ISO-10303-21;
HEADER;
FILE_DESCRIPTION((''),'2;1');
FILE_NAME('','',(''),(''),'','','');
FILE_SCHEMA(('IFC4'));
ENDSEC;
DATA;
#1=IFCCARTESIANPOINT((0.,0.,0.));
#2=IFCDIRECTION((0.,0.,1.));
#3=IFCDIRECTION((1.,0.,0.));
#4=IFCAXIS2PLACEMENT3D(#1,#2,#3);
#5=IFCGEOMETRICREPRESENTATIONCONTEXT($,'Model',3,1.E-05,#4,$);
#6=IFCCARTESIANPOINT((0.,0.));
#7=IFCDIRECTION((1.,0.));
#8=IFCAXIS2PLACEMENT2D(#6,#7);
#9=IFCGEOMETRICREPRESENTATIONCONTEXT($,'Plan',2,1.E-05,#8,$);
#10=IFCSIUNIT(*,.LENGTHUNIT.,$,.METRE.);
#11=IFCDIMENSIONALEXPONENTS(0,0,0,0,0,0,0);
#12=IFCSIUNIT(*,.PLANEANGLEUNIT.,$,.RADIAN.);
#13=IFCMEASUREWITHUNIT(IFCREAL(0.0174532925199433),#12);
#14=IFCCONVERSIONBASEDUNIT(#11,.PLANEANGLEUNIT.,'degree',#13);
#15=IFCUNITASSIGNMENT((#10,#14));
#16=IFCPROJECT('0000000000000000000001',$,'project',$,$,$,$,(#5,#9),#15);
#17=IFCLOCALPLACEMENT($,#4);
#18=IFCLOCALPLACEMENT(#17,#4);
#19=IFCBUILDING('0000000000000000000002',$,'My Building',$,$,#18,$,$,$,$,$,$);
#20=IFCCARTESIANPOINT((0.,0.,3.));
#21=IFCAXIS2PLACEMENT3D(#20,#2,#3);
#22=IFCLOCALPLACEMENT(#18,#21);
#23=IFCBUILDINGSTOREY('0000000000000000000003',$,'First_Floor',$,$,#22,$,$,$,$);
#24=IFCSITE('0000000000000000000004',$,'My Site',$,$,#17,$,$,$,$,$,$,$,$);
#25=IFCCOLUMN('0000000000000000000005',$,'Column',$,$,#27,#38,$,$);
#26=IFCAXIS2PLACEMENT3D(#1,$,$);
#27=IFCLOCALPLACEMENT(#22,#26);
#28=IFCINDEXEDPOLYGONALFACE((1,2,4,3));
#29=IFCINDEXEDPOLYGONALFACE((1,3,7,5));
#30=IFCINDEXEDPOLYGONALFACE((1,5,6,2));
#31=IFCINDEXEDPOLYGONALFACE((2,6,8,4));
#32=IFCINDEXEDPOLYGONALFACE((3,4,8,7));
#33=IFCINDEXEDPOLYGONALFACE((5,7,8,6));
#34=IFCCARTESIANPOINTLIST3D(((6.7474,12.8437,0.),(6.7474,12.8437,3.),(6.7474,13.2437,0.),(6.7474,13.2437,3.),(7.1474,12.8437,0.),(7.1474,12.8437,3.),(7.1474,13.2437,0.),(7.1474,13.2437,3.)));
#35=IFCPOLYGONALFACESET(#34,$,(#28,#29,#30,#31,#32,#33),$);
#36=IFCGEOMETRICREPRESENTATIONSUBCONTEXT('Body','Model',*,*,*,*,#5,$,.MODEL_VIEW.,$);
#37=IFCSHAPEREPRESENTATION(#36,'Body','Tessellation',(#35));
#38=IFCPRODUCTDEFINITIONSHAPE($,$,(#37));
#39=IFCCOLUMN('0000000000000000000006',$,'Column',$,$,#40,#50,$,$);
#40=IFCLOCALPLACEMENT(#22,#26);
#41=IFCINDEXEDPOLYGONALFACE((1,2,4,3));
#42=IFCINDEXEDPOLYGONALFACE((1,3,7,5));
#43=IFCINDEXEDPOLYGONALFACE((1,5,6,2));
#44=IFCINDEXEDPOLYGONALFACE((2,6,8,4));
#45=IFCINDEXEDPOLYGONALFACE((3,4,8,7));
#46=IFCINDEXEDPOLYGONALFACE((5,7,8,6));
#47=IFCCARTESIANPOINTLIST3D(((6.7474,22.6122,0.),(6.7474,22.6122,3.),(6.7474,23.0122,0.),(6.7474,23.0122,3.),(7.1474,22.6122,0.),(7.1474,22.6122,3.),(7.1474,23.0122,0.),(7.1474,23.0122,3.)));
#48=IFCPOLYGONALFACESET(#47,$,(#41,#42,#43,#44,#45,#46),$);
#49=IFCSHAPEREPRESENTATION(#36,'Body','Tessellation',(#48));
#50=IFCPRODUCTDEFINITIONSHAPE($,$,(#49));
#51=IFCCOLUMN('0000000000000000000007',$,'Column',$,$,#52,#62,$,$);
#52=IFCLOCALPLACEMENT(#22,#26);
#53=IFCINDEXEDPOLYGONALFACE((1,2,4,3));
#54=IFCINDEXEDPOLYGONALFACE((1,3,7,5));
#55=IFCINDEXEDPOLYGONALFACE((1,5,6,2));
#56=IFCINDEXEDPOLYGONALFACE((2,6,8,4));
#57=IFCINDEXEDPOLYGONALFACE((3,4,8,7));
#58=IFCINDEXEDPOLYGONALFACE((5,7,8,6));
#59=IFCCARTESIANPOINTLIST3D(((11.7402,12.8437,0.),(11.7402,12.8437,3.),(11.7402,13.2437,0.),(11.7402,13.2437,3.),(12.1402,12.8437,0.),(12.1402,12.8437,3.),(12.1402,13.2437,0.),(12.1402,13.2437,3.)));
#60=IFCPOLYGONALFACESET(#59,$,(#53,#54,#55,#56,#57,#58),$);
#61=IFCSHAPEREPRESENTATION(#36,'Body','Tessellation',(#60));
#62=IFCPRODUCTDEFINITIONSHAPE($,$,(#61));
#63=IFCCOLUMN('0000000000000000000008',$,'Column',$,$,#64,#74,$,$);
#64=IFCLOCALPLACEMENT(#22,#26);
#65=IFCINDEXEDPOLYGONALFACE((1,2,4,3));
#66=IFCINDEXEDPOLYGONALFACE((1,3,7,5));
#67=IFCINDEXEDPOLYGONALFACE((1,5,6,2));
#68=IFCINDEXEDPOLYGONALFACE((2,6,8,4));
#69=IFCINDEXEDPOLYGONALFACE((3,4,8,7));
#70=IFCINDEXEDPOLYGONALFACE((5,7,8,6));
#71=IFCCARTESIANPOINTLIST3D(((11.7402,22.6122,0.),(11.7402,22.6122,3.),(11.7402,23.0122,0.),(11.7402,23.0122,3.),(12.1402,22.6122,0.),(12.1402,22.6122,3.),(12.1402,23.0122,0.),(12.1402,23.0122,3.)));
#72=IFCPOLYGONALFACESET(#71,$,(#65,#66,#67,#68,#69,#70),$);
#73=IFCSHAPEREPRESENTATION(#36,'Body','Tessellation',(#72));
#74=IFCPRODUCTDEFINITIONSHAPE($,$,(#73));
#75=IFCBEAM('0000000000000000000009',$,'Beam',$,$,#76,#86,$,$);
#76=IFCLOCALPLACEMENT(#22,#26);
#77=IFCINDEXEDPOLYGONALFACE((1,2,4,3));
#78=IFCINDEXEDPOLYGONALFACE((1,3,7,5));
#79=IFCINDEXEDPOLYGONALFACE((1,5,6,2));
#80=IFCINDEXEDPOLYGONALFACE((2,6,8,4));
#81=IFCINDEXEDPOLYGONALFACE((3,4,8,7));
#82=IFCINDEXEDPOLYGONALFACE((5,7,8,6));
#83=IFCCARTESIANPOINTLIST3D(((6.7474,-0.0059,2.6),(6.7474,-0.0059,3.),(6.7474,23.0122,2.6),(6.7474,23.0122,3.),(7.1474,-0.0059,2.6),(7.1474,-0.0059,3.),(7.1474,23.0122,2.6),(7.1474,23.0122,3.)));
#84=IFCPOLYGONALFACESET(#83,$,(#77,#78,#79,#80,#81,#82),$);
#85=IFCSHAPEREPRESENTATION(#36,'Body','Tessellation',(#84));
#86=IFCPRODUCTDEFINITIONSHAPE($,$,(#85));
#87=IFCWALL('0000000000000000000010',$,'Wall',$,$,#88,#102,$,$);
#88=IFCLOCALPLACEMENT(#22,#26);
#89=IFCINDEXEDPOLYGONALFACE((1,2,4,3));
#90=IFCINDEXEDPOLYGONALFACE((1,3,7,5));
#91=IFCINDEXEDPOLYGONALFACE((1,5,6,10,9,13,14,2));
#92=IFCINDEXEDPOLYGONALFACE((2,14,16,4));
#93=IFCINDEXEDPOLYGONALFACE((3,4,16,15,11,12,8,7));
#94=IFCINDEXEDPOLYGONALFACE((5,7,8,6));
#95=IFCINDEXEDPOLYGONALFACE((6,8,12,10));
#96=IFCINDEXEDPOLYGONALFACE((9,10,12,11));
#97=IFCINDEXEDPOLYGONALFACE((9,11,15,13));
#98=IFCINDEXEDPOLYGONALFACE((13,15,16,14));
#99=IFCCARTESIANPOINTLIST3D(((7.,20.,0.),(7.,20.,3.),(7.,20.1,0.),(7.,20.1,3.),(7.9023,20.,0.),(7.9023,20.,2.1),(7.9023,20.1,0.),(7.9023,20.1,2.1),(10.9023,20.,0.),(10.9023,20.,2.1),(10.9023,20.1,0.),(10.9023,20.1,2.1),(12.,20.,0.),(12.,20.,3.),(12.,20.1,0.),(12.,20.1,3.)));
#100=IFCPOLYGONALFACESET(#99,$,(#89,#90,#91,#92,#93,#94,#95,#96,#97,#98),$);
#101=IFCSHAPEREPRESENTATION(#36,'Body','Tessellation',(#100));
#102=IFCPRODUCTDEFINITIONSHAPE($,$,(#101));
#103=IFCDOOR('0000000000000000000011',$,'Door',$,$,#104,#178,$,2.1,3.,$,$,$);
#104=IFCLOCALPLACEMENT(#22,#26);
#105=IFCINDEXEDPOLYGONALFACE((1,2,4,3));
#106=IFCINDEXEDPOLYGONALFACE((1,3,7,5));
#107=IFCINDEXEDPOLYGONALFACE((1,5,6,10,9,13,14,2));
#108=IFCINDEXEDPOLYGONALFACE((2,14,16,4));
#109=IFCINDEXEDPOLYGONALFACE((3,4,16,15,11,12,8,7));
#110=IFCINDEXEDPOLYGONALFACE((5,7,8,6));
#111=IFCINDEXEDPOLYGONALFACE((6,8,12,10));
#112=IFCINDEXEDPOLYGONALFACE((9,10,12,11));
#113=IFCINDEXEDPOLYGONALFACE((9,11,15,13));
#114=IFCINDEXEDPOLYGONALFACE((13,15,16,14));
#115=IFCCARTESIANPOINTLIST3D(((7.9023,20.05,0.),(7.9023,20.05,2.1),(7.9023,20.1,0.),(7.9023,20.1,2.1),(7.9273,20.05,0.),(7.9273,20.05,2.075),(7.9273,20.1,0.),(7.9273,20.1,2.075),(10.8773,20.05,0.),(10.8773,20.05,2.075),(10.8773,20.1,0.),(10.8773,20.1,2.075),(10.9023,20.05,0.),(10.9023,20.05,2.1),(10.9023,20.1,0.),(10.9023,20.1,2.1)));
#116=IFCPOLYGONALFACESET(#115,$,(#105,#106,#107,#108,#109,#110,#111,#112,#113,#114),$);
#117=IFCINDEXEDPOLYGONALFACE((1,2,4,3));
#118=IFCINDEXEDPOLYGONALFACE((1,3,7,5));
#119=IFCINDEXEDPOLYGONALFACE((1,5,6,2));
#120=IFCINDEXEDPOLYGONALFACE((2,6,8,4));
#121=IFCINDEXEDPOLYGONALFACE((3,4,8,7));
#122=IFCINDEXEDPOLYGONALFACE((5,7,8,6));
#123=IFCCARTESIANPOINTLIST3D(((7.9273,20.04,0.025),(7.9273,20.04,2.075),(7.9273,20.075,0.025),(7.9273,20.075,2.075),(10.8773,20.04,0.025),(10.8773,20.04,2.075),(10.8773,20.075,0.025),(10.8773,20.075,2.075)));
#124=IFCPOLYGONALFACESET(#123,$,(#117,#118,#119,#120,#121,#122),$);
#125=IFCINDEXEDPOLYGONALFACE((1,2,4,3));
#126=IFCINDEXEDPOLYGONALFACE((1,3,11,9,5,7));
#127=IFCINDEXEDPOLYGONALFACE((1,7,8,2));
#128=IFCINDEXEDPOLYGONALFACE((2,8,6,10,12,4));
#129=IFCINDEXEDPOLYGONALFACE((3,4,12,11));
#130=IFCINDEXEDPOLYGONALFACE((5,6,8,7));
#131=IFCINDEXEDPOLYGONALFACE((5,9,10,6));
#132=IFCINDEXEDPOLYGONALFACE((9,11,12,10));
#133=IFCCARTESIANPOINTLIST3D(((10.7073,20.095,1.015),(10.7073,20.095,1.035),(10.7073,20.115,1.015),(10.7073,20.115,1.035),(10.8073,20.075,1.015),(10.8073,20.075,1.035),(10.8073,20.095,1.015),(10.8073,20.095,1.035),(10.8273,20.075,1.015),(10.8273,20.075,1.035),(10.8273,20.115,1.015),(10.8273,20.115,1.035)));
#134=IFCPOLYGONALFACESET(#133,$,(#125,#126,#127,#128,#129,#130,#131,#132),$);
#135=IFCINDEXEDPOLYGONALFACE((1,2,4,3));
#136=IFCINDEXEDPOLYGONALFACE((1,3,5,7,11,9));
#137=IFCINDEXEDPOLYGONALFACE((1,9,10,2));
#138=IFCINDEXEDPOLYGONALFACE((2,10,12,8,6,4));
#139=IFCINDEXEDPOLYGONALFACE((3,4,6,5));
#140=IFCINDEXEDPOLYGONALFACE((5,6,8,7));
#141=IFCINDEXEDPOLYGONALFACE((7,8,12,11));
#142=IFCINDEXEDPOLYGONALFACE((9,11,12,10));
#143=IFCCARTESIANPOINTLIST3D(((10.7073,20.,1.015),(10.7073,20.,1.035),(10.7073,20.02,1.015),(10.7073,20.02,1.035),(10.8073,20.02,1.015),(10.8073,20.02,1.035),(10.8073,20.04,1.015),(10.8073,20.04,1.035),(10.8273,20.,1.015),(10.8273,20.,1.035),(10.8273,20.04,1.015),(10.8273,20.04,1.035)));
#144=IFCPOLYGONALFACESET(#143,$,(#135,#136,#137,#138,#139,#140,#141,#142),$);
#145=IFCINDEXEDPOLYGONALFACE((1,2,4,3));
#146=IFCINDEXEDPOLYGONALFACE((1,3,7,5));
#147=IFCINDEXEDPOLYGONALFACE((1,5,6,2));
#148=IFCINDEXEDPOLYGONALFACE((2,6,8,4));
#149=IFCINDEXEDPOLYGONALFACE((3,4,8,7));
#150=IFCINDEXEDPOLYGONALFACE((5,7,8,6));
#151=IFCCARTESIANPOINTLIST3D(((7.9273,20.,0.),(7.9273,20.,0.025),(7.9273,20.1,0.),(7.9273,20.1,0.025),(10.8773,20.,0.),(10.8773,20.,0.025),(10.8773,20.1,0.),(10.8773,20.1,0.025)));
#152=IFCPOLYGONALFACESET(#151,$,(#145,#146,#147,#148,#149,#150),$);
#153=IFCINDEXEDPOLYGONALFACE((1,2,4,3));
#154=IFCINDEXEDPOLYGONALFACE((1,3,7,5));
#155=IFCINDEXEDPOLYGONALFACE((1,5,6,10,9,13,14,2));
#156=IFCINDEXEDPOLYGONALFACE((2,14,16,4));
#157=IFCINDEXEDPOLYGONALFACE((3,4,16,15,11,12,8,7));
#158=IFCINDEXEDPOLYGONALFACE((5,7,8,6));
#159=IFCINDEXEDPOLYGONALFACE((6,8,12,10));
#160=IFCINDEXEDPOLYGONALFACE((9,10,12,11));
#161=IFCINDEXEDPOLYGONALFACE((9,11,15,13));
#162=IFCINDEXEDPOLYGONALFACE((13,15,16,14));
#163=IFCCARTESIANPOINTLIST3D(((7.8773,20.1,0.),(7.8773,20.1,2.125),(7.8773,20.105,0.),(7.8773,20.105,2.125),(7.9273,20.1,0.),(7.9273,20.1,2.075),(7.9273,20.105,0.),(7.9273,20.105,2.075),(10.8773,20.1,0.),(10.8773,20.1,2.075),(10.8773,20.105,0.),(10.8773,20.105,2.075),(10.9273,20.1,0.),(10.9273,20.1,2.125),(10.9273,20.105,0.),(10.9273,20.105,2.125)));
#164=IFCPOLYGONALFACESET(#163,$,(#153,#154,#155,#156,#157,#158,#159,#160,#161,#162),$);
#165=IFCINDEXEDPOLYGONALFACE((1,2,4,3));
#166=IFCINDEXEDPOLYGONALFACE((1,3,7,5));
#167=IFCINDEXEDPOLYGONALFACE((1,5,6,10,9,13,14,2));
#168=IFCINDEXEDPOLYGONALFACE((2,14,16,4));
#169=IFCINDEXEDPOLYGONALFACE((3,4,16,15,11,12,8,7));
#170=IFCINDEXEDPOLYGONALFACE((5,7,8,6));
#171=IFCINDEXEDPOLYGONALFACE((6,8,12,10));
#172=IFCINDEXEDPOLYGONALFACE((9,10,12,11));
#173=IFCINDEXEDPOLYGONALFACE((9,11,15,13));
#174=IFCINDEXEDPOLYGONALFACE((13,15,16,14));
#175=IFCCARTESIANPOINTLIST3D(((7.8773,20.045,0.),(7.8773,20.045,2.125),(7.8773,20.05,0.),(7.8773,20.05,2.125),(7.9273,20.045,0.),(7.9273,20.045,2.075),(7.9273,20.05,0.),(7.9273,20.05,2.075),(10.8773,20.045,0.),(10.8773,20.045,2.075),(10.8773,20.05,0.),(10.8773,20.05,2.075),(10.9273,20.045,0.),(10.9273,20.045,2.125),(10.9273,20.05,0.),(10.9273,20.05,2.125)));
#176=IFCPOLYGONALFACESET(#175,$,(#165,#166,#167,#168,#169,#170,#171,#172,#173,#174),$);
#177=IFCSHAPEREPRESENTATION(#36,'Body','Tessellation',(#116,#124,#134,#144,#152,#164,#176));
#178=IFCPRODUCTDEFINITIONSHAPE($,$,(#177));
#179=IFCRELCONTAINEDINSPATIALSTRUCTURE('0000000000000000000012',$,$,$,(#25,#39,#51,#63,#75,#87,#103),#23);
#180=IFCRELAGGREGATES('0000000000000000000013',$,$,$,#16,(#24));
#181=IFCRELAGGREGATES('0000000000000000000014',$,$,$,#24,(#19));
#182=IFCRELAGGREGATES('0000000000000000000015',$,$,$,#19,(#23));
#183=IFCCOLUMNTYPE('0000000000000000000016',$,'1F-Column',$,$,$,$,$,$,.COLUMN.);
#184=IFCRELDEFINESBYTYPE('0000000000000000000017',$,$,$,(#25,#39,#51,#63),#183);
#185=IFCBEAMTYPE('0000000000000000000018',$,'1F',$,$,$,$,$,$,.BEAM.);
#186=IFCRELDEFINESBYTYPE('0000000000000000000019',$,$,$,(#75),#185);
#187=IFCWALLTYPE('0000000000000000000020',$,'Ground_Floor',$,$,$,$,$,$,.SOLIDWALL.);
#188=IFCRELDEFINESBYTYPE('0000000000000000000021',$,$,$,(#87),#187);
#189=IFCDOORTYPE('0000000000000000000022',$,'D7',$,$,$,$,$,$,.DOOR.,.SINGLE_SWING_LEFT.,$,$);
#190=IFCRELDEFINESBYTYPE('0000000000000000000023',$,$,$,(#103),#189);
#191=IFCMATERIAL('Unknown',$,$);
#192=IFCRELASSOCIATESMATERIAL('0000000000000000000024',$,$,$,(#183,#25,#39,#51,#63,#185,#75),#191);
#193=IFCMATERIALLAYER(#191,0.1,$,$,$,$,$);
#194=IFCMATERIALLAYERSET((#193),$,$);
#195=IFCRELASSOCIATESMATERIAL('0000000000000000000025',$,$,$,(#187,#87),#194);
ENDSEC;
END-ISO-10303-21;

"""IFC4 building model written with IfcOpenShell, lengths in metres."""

from ifc_helpers import new_model, entity, si_unit, converted_unit, frame, origin_with_axes, origin_2d_with_axis, place, context, subcontext, project, spatial, line, indexed_curve, rectangle, outline, extrude, shape, source, transform, mapped, material, layer, layer_set, layer_usage, material_profile, profile_set, profile_usage, type_object, type_shapes, element, fill, save


model = new_model("IFC4")

# Units and contexts
model_context = context("Model", 3, precision=1e-05, world=origin_with_axes())
plan_context = context("Plan", 2, precision=1e-05, world=origin_2d_with_axis())
body_context_1 = subcontext(model_context, "Body", "Model", "MODEL_VIEW")
body_context_2 = subcontext(plan_context, "Body", "Plan", "PLAN_VIEW")
ifc_project = project(units=[si_unit("LENGTHUNIT", "METRE"), converted_unit("PLANEANGLEUNIT", "degree", entity("IfcReal", 0.0174532925199433), si_unit("PLANEANGLEUNIT", "RADIAN"), dimensions=[0, 0, 0, 0, 0, 0, 0])], contexts=[model_context, plan_context])

# Site, building, storey
site_placement = place(None, origin_with_axes())
site = spatial("IfcSite", under=ifc_project, at=site_placement, Name="My Site")
building_placement = place(site_placement, origin_with_axes())
building = spatial("IfcBuilding", under=site, at=building_placement, Name="My Building")
storey_placement = place(building_placement, frame((0.0, 0.0, 3.0), z_axis=(0.0, 0.0, 1.0), x_axis=(1.0, 0.0, 0.0)))
storey = spatial("IfcBuildingStorey", under=building, at=storey_placement, Name="First_Floor")

# Columns
ifc_material = material(Name="Unknown")
ifc_material_profile_1 = material_profile(ifc_material, rectangle(XDim=0.4, YDim=0.4))
ifc_profile_set_1 = profile_set([ifc_material_profile_1])
ifc_profile_usage_1 = profile_usage(ifc_profile_set_1, cardinal=5)
column_type = type_object("IfcColumnType", Name="1F-Column", PredefinedType="COLUMN", material=ifc_profile_set_1)
column_1_placement = place(storey_placement, frame((6.9474, 13.0437, 0.0), z_axis=(0.0, 0.0, 1.0), x_axis=(1.0, 0.0, 0.0)))
element("IfcColumn", 1, at=column_1_placement, inside=storey, type_object=column_type, material=ifc_profile_usage_1, Name="Column", context=body_context_1, shape_type="SweptSolid", body=[
    extrude(rectangle(XDim=0.4, YDim=0.4), origin_with_axes(), (0.0, 0.0, 1.0), 3.0),
])
ifc_profile_usage_2 = profile_usage(ifc_profile_set_1, cardinal=5)
column_2_placement = place(storey_placement, frame((6.9474, 22.8122, 0.0), z_axis=(0.0, 0.0, 1.0), x_axis=(1.0, 0.0, 0.0)))
element("IfcColumn", 2, at=column_2_placement, inside=storey, type_object=column_type, material=ifc_profile_usage_2, Name="Column", context=body_context_1, shape_type="SweptSolid", body=[
    extrude(rectangle(XDim=0.4, YDim=0.4), origin_with_axes(), (0.0, 0.0, 1.0), 3.0),
])
ifc_profile_usage_3 = profile_usage(ifc_profile_set_1, cardinal=5)
column_3_placement = place(storey_placement, frame((11.9402, 13.0437, 0.0), z_axis=(0.0, 0.0, 1.0), x_axis=(1.0, 0.0, 0.0)))
element("IfcColumn", 3, at=column_3_placement, inside=storey, type_object=column_type, material=ifc_profile_usage_3, Name="Column", context=body_context_1, shape_type="SweptSolid", body=[
    extrude(rectangle(XDim=0.4, YDim=0.4), origin_with_axes(), (0.0, 0.0, 1.0), 3.0),
])
ifc_profile_usage_4 = profile_usage(ifc_profile_set_1, cardinal=5)
column_4_placement = place(storey_placement, frame((11.9402, 22.8122, 0.0), z_axis=(0.0, 0.0, 1.0), x_axis=(1.0, 0.0, 0.0)))
element("IfcColumn", 4, at=column_4_placement, inside=storey, type_object=column_type, material=ifc_profile_usage_4, Name="Column", context=body_context_1, shape_type="SweptSolid", body=[
    extrude(rectangle(XDim=0.4, YDim=0.4), origin_with_axes(), (0.0, 0.0, 1.0), 3.0),
])

# Beam
ifc_material_profile_2 = material_profile(ifc_material, rectangle(XDim=0.4, YDim=0.4))
ifc_profile_set_2 = profile_set([ifc_material_profile_2])
ifc_profile_usage_5 = profile_usage(ifc_profile_set_2, cardinal=8)
beam_type = type_object("IfcBeamType", Name="1F", PredefinedType="BEAM", material=ifc_profile_set_2)
beam_placement = place(storey_placement, frame((6.9474, 23.0122, 3.0), z_axis=(0.0, -1.0, 0.0), x_axis=(1.0, 0.0, 0.0)))
element("IfcBeam", 5, at=beam_placement, inside=storey, type_object=beam_type, material=ifc_profile_usage_5, Name="Beam", context=body_context_1, shape_type="SweptSolid", body=[
    extrude(rectangle(XDim=0.4, YDim=0.4), frame((0.0, -0.2, 0.0), z_axis=(0.0, 0.0, 1.0), x_axis=(1.0, 0.0, 0.0)), (0.0, 0.0, 1.0), 23.0181),
])

# Wall, opening, door
ifc_layer = layer(ifc_material, 0.1)
ifc_layer_set = layer_set([ifc_layer])
ifc_layer_usage_1 = layer_usage(ifc_layer_set, "AXIS2", "POSITIVE", 0.0)
wall_type = type_object("IfcWallType", Name="Ground_Floor", PredefinedType="SOLIDWALL", material=ifc_layer_set)
wall_1_placement = place(storey_placement, frame((7.0, 20.0, 0.0), z_axis=(0.0, 0.0, 1.0), x_axis=(1.0, 0.0, 0.0)))
wall_1 = element("IfcWall", 6, at=wall_1_placement, inside=storey, type_object=wall_type, material=ifc_layer_usage_1, Name="Wall", context=body_context_1, shape_type="SweptSolid", body=[
    extrude(outline(indexed_curve([(0.0, 0.0), (0.0, 0.1), (5.0, 0.1), (5.0, 0.0)], segments=[line(1, 2, 3, 4, 1)])), origin_with_axes(), (0.0, 0.0, 1.0), 3.0),
])
shared_shape_1 = source(origin_with_axes(), body_context_1, "Body", "SweptSolid", [
    extrude(outline(indexed_curve([(0.0, 0.0), (3.0, 0.0), (3.0, 2.1), (0.0, 2.1)], segments=[line(1, 2, 3, 4, 1)])), frame((0.0, -0.6, 0.0), z_axis=(0.0, -1.0, 0.0), x_axis=(1.0, 0.0, 0.0)), (0.0, 0.0, -1.0), 1.2),
])
opening_1_placement = place(wall_1_placement, frame((3.9023, 0.1, 0.0), z_axis=(0.0, 0.0, 1.0), x_axis=(-1.0, 0.0, 0.0)))
opening_1 = element("IfcOpeningElement", 7, at=opening_1_placement, cuts=wall_1, PredefinedType="OPENING", context=body_context_1, shape_type="MappedRepresentation", body=[
    mapped(shared_shape_1, transform((0.0, 0.0, 0.0), x_axis=(1.0, 0.0, 0.0), y_axis=(0.0, 1.0, 0.0), z_axis=(0.0, 0.0, 1.0), scale=1.0)),
])
door_type_1 = type_object("IfcDoorType", Name="D7", OperationType="SINGLE_SWING_LEFT", PredefinedType="DOOR")
shared_shape_2 = source(origin_with_axes(), body_context_1, "Body", "SweptSolid", [
    extrude(outline(indexed_curve([(0.0, 0.0), (0.0, 2.1), (3.0, 2.1), (3.0, 0.0), (2.975, 0.0), (2.975, 2.075), (0.025, 2.075), (0.025, 0.0)], segments=[line(1, 2, 3, 4, 5, 6, 7, 8, 1)])), frame((0.0, 0.0, 0.0), z_axis=(0.0, -1.0, 0.0), x_axis=(1.0, 0.0, 0.0)), (0.0, 0.0, -1.0), 0.05),
    extrude(outline(indexed_curve([(0.0, 0.0), (2.95, 0.0), (2.95, 0.035), (0.0, 0.035)], segments=[line(1, 2, 3, 4, 1)])), frame((0.025, 0.025, 0.025), z_axis=(0.0, 0.0, 1.0), x_axis=(1.0, 0.0, 0.0)), (0.0, 0.0, 1.0), 2.05),
    extrude(outline(indexed_curve([(0.0, 0.0), (0.0, -0.04), (0.12, -0.04), (0.12, -0.02), (0.02, -0.02), (0.02, 0.0)], segments=[line(1, 2, 3, 4, 5, 6, 1)])), frame((0.075, 0.025, 1.015), z_axis=(0.0, 0.0, 1.0), x_axis=(1.0, 0.0, 0.0)), (0.0, 0.0, 1.0), 0.02),
    extrude(outline(indexed_curve([(0.0, 0.0), (0.0, 0.04), (0.12, 0.04), (0.12, 0.02), (0.02, 0.02), (0.02, 0.0)], segments=[line(1, 2, 3, 4, 5, 6, 1)])), frame((0.075, 0.06, 1.015), z_axis=(0.0, 0.0, 1.0), x_axis=(1.0, 0.0, 0.0)), (0.0, 0.0, 1.0), 0.02),
    extrude(outline(indexed_curve([(0.0, 0.0), (2.95, 0.0), (2.95, 0.1), (0.0, 0.1)], segments=[line(1, 2, 3, 4, 1)])), frame((0.025, 0.0, 0.0), z_axis=(0.0, 0.0, 1.0), x_axis=(1.0, 0.0, 0.0)), (0.0, 0.0, 1.0), 0.025),
    extrude(outline(indexed_curve([(0.0, 0.0), (0.0, 2.125), (3.05, 2.125), (3.05, 0.0), (3.0, 0.0), (3.0, 2.075), (0.05, 2.075), (0.05, 0.0)], segments=[line(1, 2, 3, 4, 5, 6, 7, 8, 1)])), frame((-0.025, -0.005, 0.0), z_axis=(0.0, -1.0, 0.0), x_axis=(1.0, 0.0, 0.0)), (0.0, 0.0, -1.0), 0.005),
    extrude(outline(indexed_curve([(0.0, 0.0), (0.0, 2.125), (3.05, 2.125), (3.05, 0.0), (3.0, 0.0), (3.0, 2.075), (0.05, 2.075), (0.05, 0.0)], segments=[line(1, 2, 3, 4, 5, 6, 7, 8, 1)])), frame((-0.025, 0.05, 0.0), z_axis=(0.0, -1.0, 0.0), x_axis=(1.0, 0.0, 0.0)), (0.0, 0.0, -1.0), 0.005),
])
shared_shape_3 = source(origin_with_axes(), body_context_2, "Body", "Curve2D", [
    entity("IfcIndexedPolyCurve", entity("IfcCartesianPointList2D", [[0.0, 0.0], [0.025, 0.0], [0.025, 0.05], [0.0, 0.05]]), [entity("IfcLineIndex", [1, 2, 3, 4, 1])]),
    entity("IfcIndexedPolyCurve", entity("IfcCartesianPointList2D", [[3.0, 0.0], [2.975, 0.0], [2.975, 0.05], [3.0, 0.05]]), [entity("IfcLineIndex", [1, 2, 3, 4, 1])]),
    entity("IfcIndexedPolyCurve", entity("IfcCartesianPointList2D", [[2.975, 0.05], [2.975, -2.9], [2.94, -2.9]])),
    entity("IfcTrimmedCurve", entity("IfcEllipse", entity("IfcAxis2Placement2D", entity("IfcCartesianPoint", [2.94, 0.05]), entity("IfcDirection", [1.0, 0.0])), 2.915, 2.95), [entity("IfcCartesianPoint", [2.94, 3.0])], [entity("IfcCartesianPoint", [2.94, -2.9])], True, "CARTESIAN"),
    entity("IfcIndexedPolyCurve", entity("IfcCartesianPointList2D", [[2.975, 0.05], [2.94, 0.05], [2.94, 3.0], [2.975, 3.0]]), [entity("IfcLineIndex", [1, 2, 3, 4, 1])]),
])
type_shapes(door_type_1, [shared_shape_2, shared_shape_3])
door_1_placement = place(opening_1_placement, origin_with_axes())
door_1 = element("IfcDoor", 8, at=door_1_placement, inside=storey, type_object=door_type_1, Name="Door", OverallHeight=2.1, OverallWidth=3.0, shapes=[
    shape(body_context_1, "Body", "MappedRepresentation", [mapped(shared_shape_2, transform((0.0, 0.0, 0.0), x_axis=(1.0, 0.0, 0.0), y_axis=(0.0, 1.0, 0.0), z_axis=(0.0, 0.0, 1.0), scale=1.0))]),
    shape(body_context_2, "Body", "MappedRepresentation", [mapped(shared_shape_3, transform((0.0, 0.0, 0.0), x_axis=(1.0, 0.0, 0.0), y_axis=(0.0, 1.0, 0.0), z_axis=(0.0, 0.0, 1.0), scale=1.0))]),
])
fill(opening_1, door_1)

save(model, "model.ifc")
